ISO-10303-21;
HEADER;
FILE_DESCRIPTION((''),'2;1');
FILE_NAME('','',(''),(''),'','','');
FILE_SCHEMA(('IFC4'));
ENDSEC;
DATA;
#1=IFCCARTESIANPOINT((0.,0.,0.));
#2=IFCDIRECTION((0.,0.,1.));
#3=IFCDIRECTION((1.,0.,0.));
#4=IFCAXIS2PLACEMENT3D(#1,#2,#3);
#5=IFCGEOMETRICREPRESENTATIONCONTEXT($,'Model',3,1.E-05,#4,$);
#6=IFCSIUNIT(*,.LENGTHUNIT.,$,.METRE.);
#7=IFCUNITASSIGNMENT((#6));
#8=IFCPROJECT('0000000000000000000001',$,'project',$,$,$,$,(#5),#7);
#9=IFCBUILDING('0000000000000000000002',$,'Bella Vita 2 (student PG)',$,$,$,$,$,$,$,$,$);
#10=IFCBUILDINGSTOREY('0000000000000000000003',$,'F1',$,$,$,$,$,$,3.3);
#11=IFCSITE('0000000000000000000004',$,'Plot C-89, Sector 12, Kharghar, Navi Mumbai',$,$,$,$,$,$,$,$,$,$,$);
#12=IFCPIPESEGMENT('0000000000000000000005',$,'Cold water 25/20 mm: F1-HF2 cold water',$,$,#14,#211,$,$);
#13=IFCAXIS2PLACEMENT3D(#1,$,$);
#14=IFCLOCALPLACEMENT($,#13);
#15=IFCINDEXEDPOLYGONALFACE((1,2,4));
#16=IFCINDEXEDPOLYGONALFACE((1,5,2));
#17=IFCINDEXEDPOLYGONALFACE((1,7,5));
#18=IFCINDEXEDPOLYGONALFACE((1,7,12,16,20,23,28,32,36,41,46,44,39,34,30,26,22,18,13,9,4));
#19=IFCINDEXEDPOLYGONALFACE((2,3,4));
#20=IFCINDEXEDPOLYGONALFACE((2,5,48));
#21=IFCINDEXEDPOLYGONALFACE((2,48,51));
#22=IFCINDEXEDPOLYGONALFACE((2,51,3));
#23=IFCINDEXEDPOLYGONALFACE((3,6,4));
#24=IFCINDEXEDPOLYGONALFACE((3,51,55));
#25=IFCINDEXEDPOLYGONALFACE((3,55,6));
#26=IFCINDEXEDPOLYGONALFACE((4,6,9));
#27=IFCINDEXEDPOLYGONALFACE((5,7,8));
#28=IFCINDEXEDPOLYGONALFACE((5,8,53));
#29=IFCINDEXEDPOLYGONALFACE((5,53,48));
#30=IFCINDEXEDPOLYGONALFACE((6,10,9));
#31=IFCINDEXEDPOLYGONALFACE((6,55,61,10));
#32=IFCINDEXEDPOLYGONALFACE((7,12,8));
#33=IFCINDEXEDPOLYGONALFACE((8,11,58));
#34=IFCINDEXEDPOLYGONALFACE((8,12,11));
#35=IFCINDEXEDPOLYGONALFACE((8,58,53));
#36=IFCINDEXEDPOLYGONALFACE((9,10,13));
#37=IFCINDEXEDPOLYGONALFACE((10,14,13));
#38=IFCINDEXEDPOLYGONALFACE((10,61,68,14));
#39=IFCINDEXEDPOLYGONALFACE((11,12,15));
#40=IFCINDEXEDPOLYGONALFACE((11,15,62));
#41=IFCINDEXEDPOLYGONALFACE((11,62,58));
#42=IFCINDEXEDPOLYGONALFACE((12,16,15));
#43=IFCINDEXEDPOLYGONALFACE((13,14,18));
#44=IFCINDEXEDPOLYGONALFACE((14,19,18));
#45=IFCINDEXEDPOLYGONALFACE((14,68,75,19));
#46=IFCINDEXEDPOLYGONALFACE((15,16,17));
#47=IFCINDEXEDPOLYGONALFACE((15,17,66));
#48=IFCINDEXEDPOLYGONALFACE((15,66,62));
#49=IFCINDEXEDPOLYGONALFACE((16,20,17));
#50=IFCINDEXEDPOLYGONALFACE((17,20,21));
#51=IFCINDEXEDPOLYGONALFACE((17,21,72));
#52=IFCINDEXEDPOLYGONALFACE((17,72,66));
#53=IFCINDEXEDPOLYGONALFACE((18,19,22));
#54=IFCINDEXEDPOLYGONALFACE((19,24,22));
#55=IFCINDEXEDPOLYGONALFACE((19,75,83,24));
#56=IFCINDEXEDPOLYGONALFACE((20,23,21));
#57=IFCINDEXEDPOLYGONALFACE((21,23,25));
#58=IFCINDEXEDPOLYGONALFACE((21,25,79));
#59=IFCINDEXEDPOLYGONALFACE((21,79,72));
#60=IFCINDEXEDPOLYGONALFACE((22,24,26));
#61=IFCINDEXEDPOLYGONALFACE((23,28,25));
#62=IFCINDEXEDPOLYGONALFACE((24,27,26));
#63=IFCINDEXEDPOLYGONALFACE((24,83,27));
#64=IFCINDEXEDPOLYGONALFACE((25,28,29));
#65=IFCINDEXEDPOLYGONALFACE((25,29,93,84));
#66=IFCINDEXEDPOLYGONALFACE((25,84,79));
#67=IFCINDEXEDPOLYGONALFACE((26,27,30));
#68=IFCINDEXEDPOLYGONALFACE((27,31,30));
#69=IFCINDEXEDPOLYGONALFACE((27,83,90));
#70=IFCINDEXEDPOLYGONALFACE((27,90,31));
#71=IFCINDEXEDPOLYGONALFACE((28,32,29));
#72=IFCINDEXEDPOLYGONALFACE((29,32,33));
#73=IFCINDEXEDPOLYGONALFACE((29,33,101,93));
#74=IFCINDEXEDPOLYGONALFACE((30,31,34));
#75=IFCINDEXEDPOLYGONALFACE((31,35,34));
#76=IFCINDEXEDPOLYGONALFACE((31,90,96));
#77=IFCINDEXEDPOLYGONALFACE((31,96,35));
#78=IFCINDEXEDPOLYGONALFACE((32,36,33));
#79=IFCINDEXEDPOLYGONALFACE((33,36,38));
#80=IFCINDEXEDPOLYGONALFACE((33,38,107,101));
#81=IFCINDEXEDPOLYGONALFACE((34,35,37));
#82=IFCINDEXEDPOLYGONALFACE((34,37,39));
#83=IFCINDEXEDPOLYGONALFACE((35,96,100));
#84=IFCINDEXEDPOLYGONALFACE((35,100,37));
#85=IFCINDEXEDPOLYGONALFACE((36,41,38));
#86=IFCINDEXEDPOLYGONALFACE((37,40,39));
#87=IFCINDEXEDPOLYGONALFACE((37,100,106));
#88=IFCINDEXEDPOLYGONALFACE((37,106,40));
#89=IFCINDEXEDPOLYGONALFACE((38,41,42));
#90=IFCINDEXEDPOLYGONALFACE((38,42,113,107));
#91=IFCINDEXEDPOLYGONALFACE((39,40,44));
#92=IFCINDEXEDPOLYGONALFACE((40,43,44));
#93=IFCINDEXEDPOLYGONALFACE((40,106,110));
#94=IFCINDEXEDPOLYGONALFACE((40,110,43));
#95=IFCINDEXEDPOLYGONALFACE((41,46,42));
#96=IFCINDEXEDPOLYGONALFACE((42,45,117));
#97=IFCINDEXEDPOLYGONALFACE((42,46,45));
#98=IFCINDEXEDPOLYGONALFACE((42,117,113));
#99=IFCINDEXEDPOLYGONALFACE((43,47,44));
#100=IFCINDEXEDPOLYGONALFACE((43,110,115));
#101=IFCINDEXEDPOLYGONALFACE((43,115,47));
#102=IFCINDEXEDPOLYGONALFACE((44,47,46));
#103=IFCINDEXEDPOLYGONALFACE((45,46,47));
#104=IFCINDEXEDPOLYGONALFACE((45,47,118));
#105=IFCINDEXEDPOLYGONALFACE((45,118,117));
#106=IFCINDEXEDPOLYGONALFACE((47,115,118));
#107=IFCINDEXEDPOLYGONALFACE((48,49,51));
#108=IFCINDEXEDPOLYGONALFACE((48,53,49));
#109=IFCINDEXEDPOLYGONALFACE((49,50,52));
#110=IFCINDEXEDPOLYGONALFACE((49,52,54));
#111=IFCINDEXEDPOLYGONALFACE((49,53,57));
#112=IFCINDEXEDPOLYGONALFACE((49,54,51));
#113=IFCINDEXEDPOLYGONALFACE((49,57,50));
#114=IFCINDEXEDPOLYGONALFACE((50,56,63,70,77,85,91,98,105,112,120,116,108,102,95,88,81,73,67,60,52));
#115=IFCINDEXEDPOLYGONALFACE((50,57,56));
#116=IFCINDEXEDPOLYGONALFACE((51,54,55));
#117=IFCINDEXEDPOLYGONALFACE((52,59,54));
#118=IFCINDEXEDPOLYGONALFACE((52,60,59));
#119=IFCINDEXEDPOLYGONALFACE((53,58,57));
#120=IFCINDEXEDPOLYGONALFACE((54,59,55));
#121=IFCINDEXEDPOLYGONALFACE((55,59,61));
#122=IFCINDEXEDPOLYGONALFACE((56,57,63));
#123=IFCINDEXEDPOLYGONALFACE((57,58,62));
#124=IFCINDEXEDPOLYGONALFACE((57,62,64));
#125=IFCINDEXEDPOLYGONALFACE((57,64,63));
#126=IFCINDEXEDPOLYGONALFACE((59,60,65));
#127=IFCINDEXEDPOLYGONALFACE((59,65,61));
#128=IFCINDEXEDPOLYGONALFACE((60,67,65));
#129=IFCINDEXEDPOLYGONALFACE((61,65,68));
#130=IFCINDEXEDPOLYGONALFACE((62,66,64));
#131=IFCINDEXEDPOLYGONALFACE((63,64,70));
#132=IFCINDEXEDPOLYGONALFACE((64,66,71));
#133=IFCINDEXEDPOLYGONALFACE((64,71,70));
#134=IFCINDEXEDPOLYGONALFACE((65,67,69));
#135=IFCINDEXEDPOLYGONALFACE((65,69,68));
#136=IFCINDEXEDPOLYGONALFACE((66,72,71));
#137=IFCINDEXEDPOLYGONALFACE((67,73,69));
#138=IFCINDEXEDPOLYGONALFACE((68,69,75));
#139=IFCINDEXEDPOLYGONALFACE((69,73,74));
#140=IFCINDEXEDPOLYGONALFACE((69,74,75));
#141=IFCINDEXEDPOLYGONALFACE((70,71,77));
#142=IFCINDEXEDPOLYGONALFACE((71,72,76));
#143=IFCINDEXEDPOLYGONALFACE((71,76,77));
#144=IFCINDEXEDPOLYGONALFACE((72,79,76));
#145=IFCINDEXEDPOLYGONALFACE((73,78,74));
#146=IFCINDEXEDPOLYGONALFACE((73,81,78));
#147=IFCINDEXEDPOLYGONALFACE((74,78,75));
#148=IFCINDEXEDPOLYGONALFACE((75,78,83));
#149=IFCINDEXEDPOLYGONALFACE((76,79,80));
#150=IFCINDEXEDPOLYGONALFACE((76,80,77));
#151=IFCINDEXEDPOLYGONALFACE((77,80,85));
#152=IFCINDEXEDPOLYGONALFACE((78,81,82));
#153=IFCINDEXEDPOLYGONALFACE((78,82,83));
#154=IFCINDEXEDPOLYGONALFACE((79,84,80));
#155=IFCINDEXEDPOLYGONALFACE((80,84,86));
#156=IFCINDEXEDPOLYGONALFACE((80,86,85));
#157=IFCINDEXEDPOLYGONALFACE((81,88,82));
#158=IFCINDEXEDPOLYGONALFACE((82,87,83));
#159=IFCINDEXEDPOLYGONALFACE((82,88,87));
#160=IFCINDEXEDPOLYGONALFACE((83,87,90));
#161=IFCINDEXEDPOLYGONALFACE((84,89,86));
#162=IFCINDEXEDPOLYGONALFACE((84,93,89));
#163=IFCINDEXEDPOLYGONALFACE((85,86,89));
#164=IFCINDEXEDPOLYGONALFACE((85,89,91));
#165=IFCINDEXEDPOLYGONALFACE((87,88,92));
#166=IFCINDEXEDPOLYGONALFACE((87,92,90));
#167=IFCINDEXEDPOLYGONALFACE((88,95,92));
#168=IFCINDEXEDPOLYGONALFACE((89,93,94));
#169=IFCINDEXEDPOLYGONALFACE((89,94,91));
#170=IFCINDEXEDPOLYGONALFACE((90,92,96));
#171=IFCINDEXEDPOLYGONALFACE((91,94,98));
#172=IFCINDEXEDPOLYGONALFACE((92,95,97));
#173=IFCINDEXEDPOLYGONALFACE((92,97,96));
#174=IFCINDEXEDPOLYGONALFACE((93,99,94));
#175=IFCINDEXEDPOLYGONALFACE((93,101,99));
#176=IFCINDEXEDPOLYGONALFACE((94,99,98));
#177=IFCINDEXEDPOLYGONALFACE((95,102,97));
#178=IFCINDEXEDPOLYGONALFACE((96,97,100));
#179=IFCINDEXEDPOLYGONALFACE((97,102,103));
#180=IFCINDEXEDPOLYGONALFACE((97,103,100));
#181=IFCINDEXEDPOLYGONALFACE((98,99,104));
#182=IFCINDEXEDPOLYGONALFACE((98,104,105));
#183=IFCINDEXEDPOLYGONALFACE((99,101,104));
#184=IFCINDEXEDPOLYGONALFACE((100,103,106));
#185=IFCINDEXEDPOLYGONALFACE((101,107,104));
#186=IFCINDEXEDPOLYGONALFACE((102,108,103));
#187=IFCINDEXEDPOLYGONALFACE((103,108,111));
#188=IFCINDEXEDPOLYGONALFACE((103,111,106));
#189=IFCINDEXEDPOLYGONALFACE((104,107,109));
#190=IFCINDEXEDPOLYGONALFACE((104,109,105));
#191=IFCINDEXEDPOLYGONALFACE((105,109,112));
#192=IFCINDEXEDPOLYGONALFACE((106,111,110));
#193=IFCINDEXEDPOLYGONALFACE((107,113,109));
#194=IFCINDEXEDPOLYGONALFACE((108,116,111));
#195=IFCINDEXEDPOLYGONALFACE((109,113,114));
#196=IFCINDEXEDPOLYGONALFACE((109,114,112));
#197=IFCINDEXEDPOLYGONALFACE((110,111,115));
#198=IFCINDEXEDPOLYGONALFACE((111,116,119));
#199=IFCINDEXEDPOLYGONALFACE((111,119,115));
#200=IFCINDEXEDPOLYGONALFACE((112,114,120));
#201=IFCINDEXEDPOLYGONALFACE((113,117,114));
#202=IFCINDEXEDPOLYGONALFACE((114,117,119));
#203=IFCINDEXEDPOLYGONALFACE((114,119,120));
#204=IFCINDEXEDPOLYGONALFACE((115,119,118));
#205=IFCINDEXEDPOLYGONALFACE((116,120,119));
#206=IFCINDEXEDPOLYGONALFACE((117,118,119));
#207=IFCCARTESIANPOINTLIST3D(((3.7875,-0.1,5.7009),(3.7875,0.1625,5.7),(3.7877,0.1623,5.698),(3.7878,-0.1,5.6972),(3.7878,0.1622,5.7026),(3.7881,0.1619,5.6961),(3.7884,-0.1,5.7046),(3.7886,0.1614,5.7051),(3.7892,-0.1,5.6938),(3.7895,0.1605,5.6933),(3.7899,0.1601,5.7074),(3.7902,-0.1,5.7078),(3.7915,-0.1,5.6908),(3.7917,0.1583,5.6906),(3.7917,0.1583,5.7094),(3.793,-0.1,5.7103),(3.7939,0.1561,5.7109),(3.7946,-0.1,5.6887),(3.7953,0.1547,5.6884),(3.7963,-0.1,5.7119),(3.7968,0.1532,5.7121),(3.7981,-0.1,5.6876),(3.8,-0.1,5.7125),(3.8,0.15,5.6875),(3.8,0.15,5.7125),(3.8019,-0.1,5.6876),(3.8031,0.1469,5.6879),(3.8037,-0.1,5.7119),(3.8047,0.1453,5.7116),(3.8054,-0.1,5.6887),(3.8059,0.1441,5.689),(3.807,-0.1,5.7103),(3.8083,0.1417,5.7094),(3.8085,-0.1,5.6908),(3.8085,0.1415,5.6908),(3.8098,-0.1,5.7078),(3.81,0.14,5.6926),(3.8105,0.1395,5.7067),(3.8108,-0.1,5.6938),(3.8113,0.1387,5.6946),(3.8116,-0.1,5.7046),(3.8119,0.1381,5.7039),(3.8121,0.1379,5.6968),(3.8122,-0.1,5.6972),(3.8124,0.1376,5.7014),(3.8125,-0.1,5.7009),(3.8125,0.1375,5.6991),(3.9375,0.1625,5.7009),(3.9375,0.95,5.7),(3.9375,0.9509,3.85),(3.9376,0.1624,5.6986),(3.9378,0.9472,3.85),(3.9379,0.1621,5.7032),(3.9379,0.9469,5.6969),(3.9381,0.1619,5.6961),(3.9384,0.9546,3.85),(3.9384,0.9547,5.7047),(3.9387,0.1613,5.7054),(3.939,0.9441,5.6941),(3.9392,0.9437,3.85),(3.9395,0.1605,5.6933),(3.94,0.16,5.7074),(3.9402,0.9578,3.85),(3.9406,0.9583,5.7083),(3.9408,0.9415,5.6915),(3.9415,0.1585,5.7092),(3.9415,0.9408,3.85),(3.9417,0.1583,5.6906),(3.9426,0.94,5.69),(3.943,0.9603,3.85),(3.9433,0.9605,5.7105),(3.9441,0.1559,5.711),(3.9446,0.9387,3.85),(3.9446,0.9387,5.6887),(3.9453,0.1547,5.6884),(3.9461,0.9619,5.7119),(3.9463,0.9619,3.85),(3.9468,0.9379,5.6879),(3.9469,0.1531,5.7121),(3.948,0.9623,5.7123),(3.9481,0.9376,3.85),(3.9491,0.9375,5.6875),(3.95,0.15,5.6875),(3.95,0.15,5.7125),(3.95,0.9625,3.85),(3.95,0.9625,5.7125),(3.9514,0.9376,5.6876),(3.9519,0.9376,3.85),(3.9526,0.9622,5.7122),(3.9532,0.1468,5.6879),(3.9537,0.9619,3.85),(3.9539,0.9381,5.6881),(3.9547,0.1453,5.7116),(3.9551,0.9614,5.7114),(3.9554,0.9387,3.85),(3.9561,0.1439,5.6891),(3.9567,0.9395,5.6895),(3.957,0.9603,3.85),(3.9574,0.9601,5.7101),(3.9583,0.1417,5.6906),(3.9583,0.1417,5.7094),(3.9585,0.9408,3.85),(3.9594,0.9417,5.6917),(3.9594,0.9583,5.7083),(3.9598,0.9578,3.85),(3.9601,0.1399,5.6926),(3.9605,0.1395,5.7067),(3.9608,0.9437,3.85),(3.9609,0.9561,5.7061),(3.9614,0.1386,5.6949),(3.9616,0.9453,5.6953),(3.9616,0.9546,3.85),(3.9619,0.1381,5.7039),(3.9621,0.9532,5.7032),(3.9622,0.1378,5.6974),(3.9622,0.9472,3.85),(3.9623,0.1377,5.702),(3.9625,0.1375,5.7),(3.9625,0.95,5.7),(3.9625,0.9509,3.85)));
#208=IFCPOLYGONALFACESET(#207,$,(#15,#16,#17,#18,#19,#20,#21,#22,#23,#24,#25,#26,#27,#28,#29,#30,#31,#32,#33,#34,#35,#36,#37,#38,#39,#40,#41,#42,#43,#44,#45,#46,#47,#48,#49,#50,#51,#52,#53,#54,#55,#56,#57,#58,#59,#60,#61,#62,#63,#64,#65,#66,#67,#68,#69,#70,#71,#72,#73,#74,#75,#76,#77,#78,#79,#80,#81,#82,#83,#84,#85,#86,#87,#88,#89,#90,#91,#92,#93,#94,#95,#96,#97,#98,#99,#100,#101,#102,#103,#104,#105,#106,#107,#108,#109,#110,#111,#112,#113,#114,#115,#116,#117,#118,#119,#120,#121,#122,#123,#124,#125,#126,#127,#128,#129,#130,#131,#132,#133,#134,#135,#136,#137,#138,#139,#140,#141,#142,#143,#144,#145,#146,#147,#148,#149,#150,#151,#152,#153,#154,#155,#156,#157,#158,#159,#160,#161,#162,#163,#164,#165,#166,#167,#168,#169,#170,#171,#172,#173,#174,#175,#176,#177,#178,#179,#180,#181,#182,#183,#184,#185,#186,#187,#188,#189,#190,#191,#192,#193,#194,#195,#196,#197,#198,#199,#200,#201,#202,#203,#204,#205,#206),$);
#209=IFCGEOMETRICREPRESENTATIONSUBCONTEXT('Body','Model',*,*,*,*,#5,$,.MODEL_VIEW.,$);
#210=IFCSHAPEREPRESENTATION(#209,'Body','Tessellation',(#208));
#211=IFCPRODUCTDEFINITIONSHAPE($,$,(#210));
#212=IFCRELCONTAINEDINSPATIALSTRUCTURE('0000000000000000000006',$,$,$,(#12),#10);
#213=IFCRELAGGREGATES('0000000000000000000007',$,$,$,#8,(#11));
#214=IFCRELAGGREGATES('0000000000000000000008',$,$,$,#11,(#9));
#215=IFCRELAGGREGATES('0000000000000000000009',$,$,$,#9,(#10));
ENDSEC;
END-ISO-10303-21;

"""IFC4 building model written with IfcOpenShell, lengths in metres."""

from ifc_helpers import new_model, entity, si_unit, origin, origin_with_axes, place, context, subcontext, project, spatial, element, save


model = new_model("IFC4")

# Units and contexts
model_context = context("Model", 3, precision=1e-05, world=origin_with_axes())
body_context = subcontext(model_context, "Body", "Model", "MODEL_VIEW")
ifc_project = project(units=[si_unit("LENGTHUNIT", "METRE")], contexts=[model_context])

# Site, building, storey
site = spatial("IfcSite", under=ifc_project, Name="Plot C-89, Sector 12, Kharghar, Navi Mumbai")
building = spatial("IfcBuilding", under=site, Name="Bella Vita 2 (student PG)")
storey = spatial("IfcBuildingStorey", under=building, Name="F1", Elevation=3.3)

# Pipe segment
pipe_segment_1_placement = place(None, origin())
element("IfcPipeSegment", 1, at=pipe_segment_1_placement, inside=storey, Name="Cold water 25/20 mm: F1-HF2 cold water", context=body_context, shape_type="AdvancedSweptSolid", body=[
    entity("IfcSweptDiskSolid", entity("IfcPolyline", [entity("IfcCartesianPoint", [3.8, -0.1, 5.7]), entity("IfcCartesianPoint", [3.8, 0.15, 5.7]), entity("IfcCartesianPoint", [3.95, 0.15, 5.7]), entity("IfcCartesianPoint", [3.95, 0.95, 5.7]), entity("IfcCartesianPoint", [3.95, 0.95, 3.85])]), 0.0125),
])

save(model, "model.ifc")
